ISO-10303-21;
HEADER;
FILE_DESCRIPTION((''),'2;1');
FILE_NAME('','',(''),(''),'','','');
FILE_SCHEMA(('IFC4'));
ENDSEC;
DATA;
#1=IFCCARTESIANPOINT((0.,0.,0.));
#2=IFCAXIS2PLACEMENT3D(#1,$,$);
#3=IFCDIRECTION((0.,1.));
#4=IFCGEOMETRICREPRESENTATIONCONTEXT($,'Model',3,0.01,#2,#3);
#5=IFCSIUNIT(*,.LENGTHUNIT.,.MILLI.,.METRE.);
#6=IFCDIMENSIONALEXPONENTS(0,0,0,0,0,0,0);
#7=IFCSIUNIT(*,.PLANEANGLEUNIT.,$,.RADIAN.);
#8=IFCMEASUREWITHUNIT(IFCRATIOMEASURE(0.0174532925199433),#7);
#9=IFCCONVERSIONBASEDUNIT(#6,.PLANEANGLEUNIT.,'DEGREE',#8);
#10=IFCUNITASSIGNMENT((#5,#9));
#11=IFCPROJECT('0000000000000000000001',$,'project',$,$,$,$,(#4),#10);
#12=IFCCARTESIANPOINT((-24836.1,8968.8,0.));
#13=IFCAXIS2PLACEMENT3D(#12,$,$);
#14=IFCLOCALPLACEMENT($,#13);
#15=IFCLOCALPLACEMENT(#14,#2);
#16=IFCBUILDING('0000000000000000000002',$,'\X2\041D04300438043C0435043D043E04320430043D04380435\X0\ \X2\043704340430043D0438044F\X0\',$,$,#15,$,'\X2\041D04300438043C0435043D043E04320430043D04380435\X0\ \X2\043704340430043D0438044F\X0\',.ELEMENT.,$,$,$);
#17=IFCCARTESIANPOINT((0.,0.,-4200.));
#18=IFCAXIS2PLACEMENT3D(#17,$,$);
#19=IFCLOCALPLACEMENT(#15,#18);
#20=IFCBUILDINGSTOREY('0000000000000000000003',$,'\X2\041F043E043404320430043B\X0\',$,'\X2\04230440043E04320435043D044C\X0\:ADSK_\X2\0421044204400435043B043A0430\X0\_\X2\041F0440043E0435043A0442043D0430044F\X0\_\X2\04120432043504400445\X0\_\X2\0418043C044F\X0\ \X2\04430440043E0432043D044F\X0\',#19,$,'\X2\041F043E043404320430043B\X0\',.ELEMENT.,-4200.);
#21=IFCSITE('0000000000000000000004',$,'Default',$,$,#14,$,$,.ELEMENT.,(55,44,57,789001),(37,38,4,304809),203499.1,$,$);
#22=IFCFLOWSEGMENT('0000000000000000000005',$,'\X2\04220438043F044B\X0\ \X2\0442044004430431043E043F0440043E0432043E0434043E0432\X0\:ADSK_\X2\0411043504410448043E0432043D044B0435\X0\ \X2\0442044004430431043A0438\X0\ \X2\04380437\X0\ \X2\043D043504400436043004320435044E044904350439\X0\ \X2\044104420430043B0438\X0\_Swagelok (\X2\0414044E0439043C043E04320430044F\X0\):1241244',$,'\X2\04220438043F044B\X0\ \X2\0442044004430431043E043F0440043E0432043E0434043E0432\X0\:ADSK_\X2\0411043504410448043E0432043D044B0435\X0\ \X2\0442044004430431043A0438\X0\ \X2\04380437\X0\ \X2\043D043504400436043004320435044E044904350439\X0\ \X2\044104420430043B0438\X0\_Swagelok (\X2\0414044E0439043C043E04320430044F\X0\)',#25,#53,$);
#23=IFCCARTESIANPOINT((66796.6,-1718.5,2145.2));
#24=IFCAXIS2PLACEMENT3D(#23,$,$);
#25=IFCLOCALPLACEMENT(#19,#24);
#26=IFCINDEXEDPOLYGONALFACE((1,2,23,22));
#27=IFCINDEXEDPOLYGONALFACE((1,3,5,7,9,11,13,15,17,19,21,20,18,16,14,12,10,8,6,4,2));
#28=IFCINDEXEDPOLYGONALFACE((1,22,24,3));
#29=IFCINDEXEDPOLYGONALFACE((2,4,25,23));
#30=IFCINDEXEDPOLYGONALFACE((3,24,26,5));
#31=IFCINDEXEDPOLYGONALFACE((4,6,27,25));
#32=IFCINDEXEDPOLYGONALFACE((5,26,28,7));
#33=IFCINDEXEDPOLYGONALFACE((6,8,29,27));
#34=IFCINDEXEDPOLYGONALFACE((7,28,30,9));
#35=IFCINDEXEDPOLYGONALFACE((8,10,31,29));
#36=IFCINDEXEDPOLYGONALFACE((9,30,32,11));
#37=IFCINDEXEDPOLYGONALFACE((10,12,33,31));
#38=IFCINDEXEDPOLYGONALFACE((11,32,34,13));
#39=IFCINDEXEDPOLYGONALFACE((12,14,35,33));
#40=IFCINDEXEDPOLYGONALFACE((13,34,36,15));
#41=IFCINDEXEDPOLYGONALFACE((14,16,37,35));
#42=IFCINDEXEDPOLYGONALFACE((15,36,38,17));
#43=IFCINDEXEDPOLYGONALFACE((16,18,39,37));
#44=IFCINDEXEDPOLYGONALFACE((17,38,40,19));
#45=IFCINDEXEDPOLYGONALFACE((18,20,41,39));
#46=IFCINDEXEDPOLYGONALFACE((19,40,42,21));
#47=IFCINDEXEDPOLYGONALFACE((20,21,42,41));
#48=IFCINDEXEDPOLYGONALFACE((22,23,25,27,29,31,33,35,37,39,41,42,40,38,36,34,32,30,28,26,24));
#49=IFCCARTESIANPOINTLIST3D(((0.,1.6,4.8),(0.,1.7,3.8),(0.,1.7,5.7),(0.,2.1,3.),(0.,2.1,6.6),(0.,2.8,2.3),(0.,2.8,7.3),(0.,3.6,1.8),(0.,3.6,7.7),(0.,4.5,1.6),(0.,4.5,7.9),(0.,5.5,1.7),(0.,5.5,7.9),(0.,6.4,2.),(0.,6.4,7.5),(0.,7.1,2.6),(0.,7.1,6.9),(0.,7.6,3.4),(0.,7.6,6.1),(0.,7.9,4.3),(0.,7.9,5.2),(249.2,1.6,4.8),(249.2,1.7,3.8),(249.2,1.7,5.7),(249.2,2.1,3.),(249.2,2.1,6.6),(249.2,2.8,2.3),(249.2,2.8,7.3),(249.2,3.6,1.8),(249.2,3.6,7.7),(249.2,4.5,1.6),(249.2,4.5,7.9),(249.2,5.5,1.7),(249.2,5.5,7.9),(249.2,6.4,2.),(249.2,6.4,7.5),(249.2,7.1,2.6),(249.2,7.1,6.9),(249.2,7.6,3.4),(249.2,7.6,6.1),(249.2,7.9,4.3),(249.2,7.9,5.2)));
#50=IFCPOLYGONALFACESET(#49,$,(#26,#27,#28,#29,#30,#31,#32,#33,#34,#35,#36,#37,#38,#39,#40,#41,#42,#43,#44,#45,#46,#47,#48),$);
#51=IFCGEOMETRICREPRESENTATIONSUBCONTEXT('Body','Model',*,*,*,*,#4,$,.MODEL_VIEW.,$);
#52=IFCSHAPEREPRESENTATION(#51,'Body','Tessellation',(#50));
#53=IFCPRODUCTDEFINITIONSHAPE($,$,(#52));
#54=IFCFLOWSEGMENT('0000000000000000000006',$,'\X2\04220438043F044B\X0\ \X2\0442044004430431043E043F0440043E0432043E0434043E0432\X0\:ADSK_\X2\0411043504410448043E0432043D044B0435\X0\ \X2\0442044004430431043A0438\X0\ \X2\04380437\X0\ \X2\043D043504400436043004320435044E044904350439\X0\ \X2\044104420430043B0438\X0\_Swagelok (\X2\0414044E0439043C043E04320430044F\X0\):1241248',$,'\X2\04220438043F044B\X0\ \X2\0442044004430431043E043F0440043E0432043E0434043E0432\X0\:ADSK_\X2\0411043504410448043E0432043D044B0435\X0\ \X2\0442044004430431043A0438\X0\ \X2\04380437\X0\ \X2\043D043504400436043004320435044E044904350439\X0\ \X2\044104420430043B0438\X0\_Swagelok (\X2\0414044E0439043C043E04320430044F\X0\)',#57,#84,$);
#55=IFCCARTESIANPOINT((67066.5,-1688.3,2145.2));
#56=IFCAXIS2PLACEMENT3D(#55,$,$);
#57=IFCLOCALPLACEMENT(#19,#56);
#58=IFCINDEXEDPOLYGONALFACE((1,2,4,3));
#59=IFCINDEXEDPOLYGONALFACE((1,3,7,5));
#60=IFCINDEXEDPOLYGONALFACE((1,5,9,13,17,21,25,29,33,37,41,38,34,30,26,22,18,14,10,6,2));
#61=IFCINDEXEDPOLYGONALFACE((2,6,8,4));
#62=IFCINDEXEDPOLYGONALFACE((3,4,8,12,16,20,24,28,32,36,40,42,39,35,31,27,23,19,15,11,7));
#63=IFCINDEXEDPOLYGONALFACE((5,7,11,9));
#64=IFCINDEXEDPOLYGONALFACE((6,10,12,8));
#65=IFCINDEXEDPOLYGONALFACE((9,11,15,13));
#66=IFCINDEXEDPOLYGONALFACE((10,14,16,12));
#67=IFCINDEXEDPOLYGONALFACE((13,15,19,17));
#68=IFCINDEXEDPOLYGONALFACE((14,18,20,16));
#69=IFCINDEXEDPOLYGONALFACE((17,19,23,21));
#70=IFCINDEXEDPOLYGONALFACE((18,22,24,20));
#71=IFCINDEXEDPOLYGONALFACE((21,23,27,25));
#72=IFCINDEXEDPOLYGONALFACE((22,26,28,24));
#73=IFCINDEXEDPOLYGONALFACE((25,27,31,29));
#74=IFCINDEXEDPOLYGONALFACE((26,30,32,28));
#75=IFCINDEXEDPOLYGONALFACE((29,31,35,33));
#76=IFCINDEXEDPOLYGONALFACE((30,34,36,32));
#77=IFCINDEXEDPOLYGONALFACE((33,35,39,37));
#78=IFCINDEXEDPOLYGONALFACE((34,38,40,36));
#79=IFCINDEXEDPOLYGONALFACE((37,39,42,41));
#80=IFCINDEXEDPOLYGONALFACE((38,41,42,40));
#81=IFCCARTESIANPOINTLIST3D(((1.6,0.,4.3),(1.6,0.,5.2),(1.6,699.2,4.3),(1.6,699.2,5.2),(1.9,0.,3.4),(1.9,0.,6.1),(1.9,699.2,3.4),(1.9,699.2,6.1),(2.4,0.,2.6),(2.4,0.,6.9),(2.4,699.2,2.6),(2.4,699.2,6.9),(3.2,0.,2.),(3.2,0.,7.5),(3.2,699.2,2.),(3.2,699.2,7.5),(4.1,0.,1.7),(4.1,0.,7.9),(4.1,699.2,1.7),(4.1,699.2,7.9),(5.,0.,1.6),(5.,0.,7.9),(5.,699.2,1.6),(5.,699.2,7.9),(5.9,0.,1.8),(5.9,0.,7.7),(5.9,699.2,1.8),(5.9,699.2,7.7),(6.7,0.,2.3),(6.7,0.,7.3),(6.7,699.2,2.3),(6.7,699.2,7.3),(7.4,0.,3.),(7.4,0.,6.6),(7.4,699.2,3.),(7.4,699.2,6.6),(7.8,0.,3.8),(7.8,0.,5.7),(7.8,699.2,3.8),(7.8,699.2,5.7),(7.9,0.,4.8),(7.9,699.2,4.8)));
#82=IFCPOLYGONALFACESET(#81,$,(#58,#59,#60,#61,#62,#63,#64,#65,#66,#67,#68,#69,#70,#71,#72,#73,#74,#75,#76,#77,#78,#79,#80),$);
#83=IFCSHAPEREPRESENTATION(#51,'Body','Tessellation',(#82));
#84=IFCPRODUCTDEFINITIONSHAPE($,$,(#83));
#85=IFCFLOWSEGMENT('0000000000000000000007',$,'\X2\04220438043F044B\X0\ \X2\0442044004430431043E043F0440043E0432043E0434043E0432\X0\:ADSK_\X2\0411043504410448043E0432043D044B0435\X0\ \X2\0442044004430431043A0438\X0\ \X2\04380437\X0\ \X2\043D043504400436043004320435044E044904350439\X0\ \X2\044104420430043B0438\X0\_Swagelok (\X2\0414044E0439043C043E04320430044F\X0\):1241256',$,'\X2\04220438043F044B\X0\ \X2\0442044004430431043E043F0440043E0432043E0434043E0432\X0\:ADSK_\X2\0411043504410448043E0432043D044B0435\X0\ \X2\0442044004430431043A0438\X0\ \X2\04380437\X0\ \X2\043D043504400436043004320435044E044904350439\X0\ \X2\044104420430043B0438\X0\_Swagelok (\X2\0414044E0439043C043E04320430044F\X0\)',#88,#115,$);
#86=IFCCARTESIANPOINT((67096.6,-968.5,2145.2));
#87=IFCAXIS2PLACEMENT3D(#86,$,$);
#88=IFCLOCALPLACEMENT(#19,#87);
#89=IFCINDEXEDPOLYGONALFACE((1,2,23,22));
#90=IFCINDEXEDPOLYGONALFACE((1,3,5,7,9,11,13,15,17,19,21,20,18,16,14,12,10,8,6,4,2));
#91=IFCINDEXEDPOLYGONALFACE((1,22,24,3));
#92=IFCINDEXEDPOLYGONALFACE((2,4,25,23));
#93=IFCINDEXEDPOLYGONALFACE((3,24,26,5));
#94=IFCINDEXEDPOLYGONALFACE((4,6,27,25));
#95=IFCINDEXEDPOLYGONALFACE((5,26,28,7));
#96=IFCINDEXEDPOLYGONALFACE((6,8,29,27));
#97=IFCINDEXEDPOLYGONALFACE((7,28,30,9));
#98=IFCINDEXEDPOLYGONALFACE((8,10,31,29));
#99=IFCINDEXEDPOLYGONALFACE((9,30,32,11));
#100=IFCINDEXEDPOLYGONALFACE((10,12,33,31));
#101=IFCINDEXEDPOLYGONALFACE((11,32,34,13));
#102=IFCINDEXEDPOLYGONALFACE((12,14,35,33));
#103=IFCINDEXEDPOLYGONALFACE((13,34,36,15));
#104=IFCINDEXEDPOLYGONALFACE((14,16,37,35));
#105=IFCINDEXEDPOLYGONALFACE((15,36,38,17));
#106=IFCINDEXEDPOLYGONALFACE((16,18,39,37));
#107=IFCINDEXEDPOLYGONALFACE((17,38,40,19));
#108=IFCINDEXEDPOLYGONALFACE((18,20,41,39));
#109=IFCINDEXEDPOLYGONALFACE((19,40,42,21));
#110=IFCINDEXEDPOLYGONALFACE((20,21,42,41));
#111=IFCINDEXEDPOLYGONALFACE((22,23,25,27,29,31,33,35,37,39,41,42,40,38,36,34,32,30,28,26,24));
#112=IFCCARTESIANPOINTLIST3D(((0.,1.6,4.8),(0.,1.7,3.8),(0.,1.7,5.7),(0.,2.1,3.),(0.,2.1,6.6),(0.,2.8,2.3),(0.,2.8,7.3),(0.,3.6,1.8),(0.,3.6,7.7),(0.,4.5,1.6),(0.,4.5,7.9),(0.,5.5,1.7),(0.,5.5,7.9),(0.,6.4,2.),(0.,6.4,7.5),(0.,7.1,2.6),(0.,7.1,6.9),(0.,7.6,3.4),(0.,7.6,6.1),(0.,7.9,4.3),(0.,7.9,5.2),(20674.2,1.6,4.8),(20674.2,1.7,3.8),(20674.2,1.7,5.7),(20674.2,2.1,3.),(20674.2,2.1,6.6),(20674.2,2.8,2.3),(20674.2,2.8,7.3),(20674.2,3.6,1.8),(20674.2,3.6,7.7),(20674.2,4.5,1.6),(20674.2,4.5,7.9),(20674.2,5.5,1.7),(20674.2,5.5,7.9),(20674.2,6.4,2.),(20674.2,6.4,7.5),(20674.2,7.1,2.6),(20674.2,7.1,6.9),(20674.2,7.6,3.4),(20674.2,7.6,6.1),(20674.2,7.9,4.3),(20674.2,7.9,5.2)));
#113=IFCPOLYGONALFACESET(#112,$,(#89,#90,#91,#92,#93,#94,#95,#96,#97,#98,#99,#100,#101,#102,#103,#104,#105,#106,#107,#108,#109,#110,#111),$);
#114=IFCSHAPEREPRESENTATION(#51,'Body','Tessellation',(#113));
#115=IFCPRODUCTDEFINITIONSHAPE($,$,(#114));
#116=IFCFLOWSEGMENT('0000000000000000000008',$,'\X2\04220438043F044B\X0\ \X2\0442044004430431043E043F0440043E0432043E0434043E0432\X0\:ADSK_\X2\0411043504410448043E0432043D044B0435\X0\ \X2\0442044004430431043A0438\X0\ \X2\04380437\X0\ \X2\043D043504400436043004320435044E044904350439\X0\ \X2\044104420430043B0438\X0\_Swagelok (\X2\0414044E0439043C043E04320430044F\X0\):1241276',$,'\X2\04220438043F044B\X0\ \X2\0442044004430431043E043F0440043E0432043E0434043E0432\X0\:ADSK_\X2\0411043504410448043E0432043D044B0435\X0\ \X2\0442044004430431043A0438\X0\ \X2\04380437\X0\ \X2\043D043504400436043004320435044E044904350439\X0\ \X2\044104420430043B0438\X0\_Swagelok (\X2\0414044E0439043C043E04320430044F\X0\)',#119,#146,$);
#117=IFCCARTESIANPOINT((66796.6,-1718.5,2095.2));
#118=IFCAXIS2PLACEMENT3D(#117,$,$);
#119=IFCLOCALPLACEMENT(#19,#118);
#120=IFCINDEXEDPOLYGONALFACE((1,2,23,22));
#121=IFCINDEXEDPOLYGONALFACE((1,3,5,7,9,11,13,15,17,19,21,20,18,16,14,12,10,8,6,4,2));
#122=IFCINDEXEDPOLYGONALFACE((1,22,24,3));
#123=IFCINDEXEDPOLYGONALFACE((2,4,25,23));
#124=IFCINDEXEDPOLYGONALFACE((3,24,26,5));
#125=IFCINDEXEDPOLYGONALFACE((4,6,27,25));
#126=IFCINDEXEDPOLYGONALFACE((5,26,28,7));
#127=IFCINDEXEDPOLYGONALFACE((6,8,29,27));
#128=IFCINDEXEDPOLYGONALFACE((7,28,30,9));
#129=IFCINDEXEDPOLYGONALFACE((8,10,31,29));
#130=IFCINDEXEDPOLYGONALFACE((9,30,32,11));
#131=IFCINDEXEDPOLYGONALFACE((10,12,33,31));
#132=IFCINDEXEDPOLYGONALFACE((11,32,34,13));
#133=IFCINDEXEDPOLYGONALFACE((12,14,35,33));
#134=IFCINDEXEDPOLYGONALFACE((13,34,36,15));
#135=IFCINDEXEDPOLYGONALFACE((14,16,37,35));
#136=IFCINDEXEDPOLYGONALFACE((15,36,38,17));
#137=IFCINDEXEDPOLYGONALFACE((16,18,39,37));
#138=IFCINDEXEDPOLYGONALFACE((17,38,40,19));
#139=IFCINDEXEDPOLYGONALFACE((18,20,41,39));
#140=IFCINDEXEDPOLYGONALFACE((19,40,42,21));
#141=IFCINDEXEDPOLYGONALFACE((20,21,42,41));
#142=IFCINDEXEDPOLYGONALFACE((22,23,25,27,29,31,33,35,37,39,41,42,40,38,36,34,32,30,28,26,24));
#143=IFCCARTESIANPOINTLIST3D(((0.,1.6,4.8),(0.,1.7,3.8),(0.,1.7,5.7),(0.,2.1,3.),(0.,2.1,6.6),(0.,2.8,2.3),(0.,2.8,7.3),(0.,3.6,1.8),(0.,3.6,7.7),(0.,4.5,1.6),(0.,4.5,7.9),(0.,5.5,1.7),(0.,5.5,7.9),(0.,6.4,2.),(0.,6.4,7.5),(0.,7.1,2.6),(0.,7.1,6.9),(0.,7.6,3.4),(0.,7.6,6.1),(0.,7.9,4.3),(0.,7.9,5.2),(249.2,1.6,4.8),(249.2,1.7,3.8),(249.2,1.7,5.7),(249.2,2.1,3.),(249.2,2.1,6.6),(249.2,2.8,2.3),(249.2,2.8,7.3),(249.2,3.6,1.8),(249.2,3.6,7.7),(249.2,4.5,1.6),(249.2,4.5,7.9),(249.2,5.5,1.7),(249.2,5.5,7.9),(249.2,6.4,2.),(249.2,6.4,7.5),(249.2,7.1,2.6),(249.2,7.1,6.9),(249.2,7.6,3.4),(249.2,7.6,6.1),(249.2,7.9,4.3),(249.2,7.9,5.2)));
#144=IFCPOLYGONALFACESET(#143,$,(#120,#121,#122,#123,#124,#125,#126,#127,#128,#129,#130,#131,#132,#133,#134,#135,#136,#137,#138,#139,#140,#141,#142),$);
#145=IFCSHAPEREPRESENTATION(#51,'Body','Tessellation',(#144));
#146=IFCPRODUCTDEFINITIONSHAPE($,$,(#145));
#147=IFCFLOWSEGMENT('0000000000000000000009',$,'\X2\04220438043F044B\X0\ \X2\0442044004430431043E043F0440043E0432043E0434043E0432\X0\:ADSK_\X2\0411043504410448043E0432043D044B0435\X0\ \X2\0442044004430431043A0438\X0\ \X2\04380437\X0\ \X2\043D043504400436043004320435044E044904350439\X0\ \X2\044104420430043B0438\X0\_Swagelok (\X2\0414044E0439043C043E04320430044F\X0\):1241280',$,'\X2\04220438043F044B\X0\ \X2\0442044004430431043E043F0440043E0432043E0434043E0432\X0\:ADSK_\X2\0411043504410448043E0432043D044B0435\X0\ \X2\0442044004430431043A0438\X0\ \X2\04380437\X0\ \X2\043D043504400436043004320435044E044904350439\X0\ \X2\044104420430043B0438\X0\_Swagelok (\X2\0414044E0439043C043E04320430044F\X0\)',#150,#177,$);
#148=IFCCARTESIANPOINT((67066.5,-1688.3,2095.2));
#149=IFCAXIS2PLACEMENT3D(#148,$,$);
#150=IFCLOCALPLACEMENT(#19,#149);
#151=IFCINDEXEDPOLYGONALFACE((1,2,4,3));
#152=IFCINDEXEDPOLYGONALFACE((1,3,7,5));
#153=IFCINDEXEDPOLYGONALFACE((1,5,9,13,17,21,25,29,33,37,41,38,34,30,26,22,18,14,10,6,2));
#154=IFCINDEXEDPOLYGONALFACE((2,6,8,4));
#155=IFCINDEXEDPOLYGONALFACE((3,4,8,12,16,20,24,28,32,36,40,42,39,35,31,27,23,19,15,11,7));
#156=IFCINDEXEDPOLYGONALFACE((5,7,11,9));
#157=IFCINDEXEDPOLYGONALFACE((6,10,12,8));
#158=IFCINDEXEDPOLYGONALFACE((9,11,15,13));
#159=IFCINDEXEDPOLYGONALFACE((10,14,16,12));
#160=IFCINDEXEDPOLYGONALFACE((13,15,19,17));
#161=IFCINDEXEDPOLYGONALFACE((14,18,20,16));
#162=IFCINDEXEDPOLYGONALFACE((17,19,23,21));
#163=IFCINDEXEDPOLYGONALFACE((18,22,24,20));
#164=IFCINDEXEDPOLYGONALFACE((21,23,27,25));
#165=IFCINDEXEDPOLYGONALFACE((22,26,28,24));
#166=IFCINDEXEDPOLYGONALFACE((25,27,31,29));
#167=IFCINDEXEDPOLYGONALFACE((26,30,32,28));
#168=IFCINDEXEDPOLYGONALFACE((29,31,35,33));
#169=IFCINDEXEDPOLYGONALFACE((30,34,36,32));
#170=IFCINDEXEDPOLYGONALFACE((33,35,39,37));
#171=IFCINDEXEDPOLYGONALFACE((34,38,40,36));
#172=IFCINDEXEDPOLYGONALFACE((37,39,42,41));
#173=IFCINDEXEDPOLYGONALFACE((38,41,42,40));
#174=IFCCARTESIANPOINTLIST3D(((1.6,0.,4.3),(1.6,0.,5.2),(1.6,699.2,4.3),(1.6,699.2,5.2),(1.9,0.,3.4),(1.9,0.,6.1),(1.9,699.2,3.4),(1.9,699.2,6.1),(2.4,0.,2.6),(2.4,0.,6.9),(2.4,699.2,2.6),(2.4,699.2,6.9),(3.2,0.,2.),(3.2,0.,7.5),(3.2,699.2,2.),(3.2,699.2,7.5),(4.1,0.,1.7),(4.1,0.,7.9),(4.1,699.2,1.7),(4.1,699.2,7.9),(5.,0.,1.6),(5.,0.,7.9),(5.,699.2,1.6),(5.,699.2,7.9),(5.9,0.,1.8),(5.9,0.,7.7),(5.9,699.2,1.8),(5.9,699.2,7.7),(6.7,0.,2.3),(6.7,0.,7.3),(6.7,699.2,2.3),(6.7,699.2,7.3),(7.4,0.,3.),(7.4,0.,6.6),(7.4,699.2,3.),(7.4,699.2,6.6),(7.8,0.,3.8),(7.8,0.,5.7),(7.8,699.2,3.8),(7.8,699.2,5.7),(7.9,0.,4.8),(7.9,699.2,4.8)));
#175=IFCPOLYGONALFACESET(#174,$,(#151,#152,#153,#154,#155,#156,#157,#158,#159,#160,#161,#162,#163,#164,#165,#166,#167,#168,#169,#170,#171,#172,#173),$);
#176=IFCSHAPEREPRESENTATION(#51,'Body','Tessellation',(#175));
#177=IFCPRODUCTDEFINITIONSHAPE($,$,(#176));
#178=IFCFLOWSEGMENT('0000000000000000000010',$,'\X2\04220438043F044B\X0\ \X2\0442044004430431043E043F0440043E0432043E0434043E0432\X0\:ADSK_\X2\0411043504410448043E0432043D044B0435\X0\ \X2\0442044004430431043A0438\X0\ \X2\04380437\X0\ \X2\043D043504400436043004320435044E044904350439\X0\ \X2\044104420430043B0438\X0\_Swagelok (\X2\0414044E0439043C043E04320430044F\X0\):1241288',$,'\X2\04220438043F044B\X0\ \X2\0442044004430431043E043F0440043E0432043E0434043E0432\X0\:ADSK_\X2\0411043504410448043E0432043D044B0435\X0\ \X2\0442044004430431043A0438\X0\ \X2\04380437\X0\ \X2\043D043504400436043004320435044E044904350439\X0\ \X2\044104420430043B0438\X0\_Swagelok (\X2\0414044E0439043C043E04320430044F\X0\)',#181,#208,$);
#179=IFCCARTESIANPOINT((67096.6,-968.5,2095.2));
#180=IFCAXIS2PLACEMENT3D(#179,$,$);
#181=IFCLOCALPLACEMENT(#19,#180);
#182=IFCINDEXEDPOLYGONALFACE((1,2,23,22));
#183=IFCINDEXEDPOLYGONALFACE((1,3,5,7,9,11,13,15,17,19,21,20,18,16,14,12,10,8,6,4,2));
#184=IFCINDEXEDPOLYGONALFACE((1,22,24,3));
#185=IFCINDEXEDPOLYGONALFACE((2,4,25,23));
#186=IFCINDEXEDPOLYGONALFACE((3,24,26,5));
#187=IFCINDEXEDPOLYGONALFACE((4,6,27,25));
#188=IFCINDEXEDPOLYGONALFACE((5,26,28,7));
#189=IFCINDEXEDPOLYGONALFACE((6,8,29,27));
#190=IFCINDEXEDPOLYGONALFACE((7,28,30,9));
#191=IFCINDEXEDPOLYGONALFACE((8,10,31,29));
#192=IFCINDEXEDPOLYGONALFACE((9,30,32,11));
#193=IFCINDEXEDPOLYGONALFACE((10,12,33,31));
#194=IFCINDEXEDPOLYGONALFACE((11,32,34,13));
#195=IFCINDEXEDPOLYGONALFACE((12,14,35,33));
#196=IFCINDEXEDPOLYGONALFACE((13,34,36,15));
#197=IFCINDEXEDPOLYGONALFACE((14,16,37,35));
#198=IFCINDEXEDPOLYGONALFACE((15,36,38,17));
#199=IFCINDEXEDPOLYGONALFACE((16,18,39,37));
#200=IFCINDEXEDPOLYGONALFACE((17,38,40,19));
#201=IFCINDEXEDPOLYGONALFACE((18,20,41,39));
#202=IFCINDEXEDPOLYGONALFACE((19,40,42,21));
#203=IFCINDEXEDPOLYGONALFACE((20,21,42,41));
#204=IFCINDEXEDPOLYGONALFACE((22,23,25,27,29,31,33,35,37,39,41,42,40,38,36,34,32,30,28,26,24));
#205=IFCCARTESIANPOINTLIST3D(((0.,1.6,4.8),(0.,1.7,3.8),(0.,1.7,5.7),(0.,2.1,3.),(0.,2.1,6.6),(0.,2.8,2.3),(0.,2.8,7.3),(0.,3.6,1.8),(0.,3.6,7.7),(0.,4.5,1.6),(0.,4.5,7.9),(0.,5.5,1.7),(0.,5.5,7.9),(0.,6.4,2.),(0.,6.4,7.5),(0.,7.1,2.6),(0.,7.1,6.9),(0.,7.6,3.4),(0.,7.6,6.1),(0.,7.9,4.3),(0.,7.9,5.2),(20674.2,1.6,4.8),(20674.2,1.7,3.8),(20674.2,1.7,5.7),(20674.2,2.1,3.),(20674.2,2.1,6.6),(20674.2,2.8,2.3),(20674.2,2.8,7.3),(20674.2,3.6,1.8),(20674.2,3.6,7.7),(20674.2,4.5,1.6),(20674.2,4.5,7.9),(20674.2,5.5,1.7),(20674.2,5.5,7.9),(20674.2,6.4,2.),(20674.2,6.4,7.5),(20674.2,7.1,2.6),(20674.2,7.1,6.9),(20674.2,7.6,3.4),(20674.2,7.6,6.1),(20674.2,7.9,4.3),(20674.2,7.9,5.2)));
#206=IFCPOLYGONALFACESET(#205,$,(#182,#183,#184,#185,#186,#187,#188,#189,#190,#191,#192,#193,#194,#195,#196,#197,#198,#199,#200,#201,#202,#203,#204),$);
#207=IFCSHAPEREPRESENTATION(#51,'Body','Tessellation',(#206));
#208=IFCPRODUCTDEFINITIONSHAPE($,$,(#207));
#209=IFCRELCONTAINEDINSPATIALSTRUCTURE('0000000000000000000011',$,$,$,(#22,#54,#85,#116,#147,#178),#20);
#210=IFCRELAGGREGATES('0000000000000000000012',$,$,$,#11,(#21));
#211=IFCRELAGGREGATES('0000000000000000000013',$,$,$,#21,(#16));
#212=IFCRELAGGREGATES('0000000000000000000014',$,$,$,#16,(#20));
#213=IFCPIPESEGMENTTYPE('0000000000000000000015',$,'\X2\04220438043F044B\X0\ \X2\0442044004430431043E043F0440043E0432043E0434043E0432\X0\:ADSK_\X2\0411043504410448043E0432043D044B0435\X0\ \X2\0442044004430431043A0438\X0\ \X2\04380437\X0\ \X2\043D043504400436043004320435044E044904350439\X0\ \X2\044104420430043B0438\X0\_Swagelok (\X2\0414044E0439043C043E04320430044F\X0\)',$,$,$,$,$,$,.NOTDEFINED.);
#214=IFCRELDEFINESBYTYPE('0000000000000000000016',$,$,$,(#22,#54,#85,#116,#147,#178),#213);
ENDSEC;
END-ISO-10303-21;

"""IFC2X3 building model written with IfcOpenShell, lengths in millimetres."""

from ifc_helpers import new_model, entity, si_unit, converted_unit, direction, frame, origin, origin_2d_with_axis, place, context, subcontext, project, spatial, circle, extrude, type_object, element, save


model = new_model("IFC2X3")

# Units and contexts
model_context = context("Model", 3, precision=0.01, world=origin(), true_north=direction((0.0, 1.0)))
body_context = subcontext(model_context, "Body", "Model", "MODEL_VIEW")
ifc_project = project(units=[si_unit("LENGTHUNIT", "METRE", prefix="MILLI"), converted_unit("PLANEANGLEUNIT", "DEGREE", entity("IfcRatioMeasure", 0.0174532925199433), si_unit("PLANEANGLEUNIT", "RADIAN"), dimensions=[0, 0, 0, 0, 0, 0, 0])], contexts=[model_context])

# Site, building, storey
site_placement = place(None, frame((-24836.1, 8968.8, 0.0)))
site = spatial("IfcSite", under=ifc_project, at=site_placement, Name="Default", CompositionType="ELEMENT", RefLatitude=(55, 44, 57, 789001), RefLongitude=(37, 38, 4, 304809), RefElevation=203499.1)
building_placement = place(site_placement, origin())
building = spatial("IfcBuilding", under=site, at=building_placement, Name="Наименование здания", LongName="Наименование здания", CompositionType="ELEMENT")
storey_placement = place(building_placement, frame((0.0, 0.0, -4200.0)))
storey = spatial("IfcBuildingStorey", under=building, at=storey_placement, Name="Подвал", ObjectType="Уровень:ADSK_Стрелка_Проектная_Вверх_Имя уровня", LongName="Подвал", CompositionType="ELEMENT", Elevation=-4200.0)

# Flow segments
pipe_segment_type_1 = type_object("IfcPipeSegmentType", Name="Типы трубопроводов:ADSK_Бесшовные трубки из нержавеющей стали_Swagelok (Дюймовая)", PredefinedType="NOTDEFINED")
flow_segment_1_placement = place(storey_placement, frame((66796.6, -1718.5, 2145.2)))
element("IfcFlowSegment", 1, at=flow_segment_1_placement, inside=storey, type_object=pipe_segment_type_1, Name="Типы трубопроводов:ADSK_Бесшовные трубки из нержавеющей стали_Swagelok (Дюймовая):1241244", ObjectType="Типы трубопроводов:ADSK_Бесшовные трубки из нержавеющей стали_Swagelok (Дюймовая)", context=body_context, shape_type="SweptSolid", body=[
    extrude(circle(Radius=3.2, at=origin_2d_with_axis()), frame((0.0, 4.8, 4.8), z_axis=(1.0, 0.0, 0.0), x_axis=(0.0, -1.0, 0.0)), (0.0, 0.0, 1.0), 249.2),
])
flow_segment_2_placement = place(storey_placement, frame((67066.5, -1688.3, 2145.2)))
element("IfcFlowSegment", 2, at=flow_segment_2_placement, inside=storey, type_object=pipe_segment_type_1, Name="Типы трубопроводов:ADSK_Бесшовные трубки из нержавеющей стали_Swagelok (Дюймовая):1241248", ObjectType="Типы трубопроводов:ADSK_Бесшовные трубки из нержавеющей стали_Swagelok (Дюймовая)", context=body_context, shape_type="SweptSolid", body=[
    extrude(circle(Radius=3.2, at=origin_2d_with_axis()), frame((4.8, 0.0, 4.8), z_axis=(0.0, 1.0, 0.0), x_axis=(1.0, 0.0, 0.0)), (0.0, 0.0, 1.0), 699.2),
])
flow_segment_3_placement = place(storey_placement, frame((67096.6, -968.5, 2145.2)))
element("IfcFlowSegment", 3, at=flow_segment_3_placement, inside=storey, type_object=pipe_segment_type_1, Name="Типы трубопроводов:ADSK_Бесшовные трубки из нержавеющей стали_Swagelok (Дюймовая):1241256", ObjectType="Типы трубопроводов:ADSK_Бесшовные трубки из нержавеющей стали_Swagelok (Дюймовая)", context=body_context, shape_type="SweptSolid", body=[
    extrude(circle(Radius=3.2, at=origin_2d_with_axis()), frame((0.0, 4.8, 4.8), z_axis=(1.0, 0.0, 0.0), x_axis=(0.0, -1.0, 0.0)), (0.0, 0.0, 1.0), 20674.2),
])
flow_segment_4_placement = place(storey_placement, frame((66796.6, -1718.5, 2095.2)))
element("IfcFlowSegment", 4, at=flow_segment_4_placement, inside=storey, type_object=pipe_segment_type_1, Name="Типы трубопроводов:ADSK_Бесшовные трубки из нержавеющей стали_Swagelok (Дюймовая):1241276", ObjectType="Типы трубопроводов:ADSK_Бесшовные трубки из нержавеющей стали_Swagelok (Дюймовая)", context=body_context, shape_type="SweptSolid", body=[
    extrude(circle(Radius=3.2, at=origin_2d_with_axis()), frame((0.0, 4.8, 4.8), z_axis=(1.0, 0.0, 0.0), x_axis=(0.0, -1.0, 0.0)), (0.0, 0.0, 1.0), 249.2),
])
flow_segment_5_placement = place(storey_placement, frame((67066.5, -1688.3, 2095.2)))
element("IfcFlowSegment", 5, at=flow_segment_5_placement, inside=storey, type_object=pipe_segment_type_1, Name="Типы трубопроводов:ADSK_Бесшовные трубки из нержавеющей стали_Swagelok (Дюймовая):1241280", ObjectType="Типы трубопроводов:ADSK_Бесшовные трубки из нержавеющей стали_Swagelok (Дюймовая)", context=body_context, shape_type="SweptSolid", body=[
    extrude(circle(Radius=3.2, at=origin_2d_with_axis()), frame((4.8, 0.0, 4.8), z_axis=(0.0, 1.0, 0.0), x_axis=(1.0, 0.0, 0.0)), (0.0, 0.0, 1.0), 699.2),
])
flow_segment_6_placement = place(storey_placement, frame((67096.6, -968.5, 2095.2)))
element("IfcFlowSegment", 6, at=flow_segment_6_placement, inside=storey, type_object=pipe_segment_type_1, Name="Типы трубопроводов:ADSK_Бесшовные трубки из нержавеющей стали_Swagelok (Дюймовая):1241288", ObjectType="Типы трубопроводов:ADSK_Бесшовные трубки из нержавеющей стали_Swagelok (Дюймовая)", context=body_context, shape_type="SweptSolid", body=[
    extrude(circle(Radius=3.2, at=origin_2d_with_axis()), frame((0.0, 4.8, 4.8), z_axis=(1.0, 0.0, 0.0), x_axis=(0.0, -1.0, 0.0)), (0.0, 0.0, 1.0), 20674.2),
])

save(model, "model.ifc")
